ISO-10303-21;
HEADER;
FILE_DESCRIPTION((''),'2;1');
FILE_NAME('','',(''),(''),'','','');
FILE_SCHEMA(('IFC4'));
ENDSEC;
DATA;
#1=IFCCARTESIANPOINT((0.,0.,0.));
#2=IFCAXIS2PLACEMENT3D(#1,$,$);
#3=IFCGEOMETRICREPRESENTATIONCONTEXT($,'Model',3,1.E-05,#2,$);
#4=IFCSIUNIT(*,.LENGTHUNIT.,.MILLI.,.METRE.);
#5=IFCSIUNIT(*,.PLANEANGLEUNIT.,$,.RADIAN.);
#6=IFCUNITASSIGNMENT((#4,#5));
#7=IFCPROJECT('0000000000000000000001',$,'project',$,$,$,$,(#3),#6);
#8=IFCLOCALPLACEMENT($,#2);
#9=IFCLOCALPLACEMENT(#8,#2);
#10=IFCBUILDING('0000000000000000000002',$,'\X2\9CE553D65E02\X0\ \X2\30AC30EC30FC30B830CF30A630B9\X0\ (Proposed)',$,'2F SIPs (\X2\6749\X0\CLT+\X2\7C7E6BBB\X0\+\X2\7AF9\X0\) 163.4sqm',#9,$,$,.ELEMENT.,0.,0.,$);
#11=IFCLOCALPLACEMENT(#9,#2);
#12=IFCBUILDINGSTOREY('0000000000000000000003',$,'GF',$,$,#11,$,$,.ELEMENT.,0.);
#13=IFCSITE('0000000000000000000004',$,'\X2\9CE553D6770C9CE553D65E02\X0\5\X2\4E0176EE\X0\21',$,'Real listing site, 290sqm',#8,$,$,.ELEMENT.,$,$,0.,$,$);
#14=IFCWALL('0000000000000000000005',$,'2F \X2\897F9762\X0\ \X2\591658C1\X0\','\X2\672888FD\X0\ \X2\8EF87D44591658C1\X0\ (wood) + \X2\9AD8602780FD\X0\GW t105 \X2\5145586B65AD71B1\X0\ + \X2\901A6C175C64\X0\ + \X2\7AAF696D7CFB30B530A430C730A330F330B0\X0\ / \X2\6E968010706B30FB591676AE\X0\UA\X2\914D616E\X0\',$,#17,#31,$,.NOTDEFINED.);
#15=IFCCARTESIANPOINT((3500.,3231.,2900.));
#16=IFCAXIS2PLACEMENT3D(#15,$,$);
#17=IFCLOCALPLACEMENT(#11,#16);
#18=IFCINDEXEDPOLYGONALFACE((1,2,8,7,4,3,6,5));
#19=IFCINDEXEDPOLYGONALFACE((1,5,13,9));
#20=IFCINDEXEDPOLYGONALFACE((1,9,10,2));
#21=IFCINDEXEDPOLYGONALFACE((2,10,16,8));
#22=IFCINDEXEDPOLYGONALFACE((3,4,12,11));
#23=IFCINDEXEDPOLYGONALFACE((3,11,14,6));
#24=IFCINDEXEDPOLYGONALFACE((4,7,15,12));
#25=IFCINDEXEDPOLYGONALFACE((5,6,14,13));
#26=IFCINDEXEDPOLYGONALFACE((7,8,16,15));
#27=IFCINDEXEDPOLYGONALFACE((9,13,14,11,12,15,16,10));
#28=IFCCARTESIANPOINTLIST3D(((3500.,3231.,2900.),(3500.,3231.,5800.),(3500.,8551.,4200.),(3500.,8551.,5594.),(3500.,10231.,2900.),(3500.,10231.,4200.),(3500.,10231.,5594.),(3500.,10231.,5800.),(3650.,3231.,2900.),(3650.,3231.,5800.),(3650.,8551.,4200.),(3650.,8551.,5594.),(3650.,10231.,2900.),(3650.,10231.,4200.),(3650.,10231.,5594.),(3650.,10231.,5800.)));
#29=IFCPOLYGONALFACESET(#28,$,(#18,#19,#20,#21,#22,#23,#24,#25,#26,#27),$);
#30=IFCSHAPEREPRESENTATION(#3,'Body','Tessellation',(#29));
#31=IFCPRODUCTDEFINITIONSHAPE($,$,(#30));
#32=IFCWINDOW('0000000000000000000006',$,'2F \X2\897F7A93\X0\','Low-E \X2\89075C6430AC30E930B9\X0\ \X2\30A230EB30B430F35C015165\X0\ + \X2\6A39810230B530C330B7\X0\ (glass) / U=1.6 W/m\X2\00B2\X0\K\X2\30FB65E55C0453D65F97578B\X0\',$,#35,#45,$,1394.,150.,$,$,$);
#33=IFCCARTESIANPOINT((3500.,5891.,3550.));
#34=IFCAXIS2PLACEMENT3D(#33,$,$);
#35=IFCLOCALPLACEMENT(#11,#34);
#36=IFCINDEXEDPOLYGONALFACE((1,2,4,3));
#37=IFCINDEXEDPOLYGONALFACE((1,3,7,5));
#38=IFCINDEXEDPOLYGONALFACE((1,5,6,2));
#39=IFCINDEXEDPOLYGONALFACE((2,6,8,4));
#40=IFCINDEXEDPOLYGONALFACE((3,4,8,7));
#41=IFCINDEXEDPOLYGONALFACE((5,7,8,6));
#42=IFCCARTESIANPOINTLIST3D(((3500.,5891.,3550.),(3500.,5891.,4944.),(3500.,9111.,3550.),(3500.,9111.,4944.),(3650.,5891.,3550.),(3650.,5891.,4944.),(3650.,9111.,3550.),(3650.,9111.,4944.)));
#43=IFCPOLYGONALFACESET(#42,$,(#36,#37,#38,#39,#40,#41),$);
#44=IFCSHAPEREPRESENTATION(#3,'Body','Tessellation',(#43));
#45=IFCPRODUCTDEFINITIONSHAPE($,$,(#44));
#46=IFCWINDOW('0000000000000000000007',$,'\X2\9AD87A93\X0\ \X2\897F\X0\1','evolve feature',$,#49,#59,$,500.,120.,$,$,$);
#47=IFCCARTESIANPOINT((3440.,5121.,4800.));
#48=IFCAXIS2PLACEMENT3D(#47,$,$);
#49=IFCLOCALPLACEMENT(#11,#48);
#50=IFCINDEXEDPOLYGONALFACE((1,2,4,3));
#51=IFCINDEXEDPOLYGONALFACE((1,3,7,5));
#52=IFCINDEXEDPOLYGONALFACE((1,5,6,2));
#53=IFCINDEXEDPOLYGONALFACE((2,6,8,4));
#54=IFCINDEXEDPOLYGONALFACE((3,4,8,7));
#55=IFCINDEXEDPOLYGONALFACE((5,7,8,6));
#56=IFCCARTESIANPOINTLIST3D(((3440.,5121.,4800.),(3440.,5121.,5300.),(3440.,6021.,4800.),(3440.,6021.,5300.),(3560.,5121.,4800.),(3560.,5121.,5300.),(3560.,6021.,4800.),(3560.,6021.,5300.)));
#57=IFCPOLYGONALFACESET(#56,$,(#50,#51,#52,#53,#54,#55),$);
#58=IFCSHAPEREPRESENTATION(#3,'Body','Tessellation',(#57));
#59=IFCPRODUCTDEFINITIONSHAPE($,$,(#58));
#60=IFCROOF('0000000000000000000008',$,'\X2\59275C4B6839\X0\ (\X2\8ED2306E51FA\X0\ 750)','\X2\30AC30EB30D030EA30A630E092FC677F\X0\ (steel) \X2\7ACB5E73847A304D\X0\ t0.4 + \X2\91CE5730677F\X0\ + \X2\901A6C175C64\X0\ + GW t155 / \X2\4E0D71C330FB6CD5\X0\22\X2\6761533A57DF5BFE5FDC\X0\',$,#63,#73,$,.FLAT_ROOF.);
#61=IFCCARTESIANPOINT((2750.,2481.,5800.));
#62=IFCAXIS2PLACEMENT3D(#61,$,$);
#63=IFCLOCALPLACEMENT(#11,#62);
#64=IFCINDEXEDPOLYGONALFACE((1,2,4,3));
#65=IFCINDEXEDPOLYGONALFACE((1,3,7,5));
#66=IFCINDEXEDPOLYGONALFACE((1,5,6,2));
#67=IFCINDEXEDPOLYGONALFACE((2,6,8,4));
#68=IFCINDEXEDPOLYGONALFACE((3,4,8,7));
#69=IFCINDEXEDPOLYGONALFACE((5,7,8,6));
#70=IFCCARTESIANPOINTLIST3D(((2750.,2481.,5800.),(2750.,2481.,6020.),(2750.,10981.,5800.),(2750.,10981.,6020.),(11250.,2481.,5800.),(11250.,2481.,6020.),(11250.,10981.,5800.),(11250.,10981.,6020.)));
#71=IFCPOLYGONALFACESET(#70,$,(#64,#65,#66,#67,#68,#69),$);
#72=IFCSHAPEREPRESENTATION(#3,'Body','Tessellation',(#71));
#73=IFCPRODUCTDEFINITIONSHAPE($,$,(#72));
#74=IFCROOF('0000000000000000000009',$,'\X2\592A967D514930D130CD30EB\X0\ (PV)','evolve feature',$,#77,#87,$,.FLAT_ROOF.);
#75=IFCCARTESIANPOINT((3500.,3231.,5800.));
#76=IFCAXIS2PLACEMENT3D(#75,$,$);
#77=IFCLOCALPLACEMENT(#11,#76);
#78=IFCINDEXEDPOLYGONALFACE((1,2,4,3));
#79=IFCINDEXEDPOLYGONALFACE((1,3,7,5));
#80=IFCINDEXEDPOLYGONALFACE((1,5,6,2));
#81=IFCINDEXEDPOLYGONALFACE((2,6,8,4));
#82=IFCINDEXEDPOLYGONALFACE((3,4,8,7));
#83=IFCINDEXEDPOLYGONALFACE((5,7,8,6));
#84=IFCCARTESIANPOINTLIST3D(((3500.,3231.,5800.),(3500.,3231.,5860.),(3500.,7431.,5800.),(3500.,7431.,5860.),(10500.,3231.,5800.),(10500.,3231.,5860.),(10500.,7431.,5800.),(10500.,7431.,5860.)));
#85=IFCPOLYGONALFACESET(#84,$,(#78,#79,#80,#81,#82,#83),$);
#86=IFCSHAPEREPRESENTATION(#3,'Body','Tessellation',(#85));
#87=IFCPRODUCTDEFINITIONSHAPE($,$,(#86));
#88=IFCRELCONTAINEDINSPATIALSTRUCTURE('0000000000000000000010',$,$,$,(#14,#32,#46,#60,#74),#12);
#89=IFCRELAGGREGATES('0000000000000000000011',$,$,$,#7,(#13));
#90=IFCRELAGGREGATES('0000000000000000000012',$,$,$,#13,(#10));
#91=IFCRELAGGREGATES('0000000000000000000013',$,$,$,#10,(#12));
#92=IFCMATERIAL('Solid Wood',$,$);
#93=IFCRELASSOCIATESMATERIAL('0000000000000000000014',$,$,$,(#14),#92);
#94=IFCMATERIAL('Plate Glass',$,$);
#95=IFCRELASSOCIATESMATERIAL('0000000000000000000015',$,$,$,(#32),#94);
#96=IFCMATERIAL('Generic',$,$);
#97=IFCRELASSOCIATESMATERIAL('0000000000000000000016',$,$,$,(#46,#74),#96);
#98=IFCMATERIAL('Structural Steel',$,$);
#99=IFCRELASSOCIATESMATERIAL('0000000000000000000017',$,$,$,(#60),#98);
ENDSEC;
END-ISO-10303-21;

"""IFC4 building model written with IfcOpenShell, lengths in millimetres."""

from ifc_helpers import new_model, si_unit, frame, frame_2d, origin, place, context, project, spatial, rectangle, extrude, material, element, fill, save


model = new_model("IFC4")

# Units and contexts
model_context = context("Model", 3, precision=1e-05, world=origin())
ifc_project = project(units=[si_unit("LENGTHUNIT", "METRE", prefix="MILLI"), si_unit("PLANEANGLEUNIT", "RADIAN")], contexts=[model_context])

# Site, building, storey
site_placement = place(None, origin())
site = spatial("IfcSite", under=ifc_project, at=site_placement, Name="鳥取県鳥取市5丁目21", ObjectType="Real listing site, 290sqm", CompositionType="ELEMENT", RefElevation=0.0)
building_placement = place(site_placement, origin())
building = spatial("IfcBuilding", under=site, at=building_placement, Name="鳥取市 ガレージハウス (Proposed)", ObjectType="2F SIPs (杉CLT+籾殻+竹) 163.4sqm", CompositionType="ELEMENT", ElevationOfRefHeight=0.0, ElevationOfTerrain=0.0)
storey_placement = place(building_placement, origin())
storey = spatial("IfcBuildingStorey", under=building, at=storey_placement, Name="GF", CompositionType="ELEMENT", Elevation=0.0)

# Shared definitions
ifc_material_1 = material(Name="Solid Wood")
ifc_material_2 = material(Name="Generic")

# Shared definitions
ifc_material_3 = material(Name="Plate Glass")

# Wall, openings, windows
wall_1_placement = place(storey_placement, frame((3500.0, 3231.0, 2900.0)))
wall_1 = element("IfcWall", 1, at=wall_1_placement, inside=storey, material=ifc_material_1, Name="2F 西面 外壁", Description="木製 軸組外壁 (wood) + 高性能GW t105 充填断熱 + 通気層 + 窯業系サイディング / 準耐火・外皮UA配慮", PredefinedType="NOTDEFINED", context=model_context, shape_type="SweptSolid", body=[
    extrude(rectangle(XDim=150.0, YDim=7000.0, at=frame_2d((75.0, 3500.0))), frame((3500.0, 3231.0, 2900.0)), (0.0, 0.0, 1.0), 2900.0),
])
opening_1_placement = place(storey_placement, frame((3500.0, 5891.0, 3550.0)))
opening_1 = element("IfcOpeningElement", 2, at=opening_1_placement, cuts=wall_1, PredefinedType="NOTDEFINED", context=model_context, shape_type="SweptSolid", body=[
    extrude(rectangle(XDim=150.0, YDim=3220.0, at=frame_2d((75.0, 1610.0))), frame((3500.0, 5891.0, 3550.0)), (0.0, 0.0, 1.0), 1394.0),
])
opening_2_placement = place(storey_placement, frame((3440.0, 5121.0, 4800.0)))
opening_2 = element("IfcOpeningElement", 3, at=opening_2_placement, cuts=wall_1, PredefinedType="NOTDEFINED", context=model_context, shape_type="SweptSolid", body=[
    extrude(rectangle(XDim=120.0, YDim=900.0, at=frame_2d((60.0, 450.0))), frame((3440.0, 5121.0, 4800.0)), (0.0, 0.0, 1.0), 500.0),
])
window_1_placement = place(storey_placement, frame((3500.0, 5891.0, 3550.0)))
window_1 = element("IfcWindow", 4, at=window_1_placement, inside=storey, material=ifc_material_3, Name="2F 西窓", Description="Low-E 複層ガラス アルゴン封入 + 樹脂サッシ (glass) / U=1.6 W/m²K・日射取得型", OverallHeight=1394.0, OverallWidth=150.0, context=model_context, shape_type="SweptSolid", body=[
    extrude(rectangle(XDim=150.0, YDim=3220.0, at=frame_2d((75.0, 1610.0))), frame((3500.0, 5891.0, 3550.0)), (0.0, 0.0, 1.0), 1394.0),
])
fill(opening_1, window_1)
window_2_placement = place(storey_placement, frame((3440.0, 5121.0, 4800.0)))
window_2 = element("IfcWindow", 5, at=window_2_placement, inside=storey, material=ifc_material_2, Name="高窓 西1", Description="evolve feature", OverallHeight=500.0, OverallWidth=120.0, context=model_context, shape_type="SweptSolid", body=[
    extrude(rectangle(XDim=120.0, YDim=900.0, at=frame_2d((60.0, 450.0))), frame((3440.0, 5121.0, 4800.0)), (0.0, 0.0, 1.0), 500.0),
])
fill(opening_2, window_2)

# Roofs
ifc_material_4 = material(Name="Structural Steel")
roof_1_placement = place(storey_placement, frame((2750.0, 2481.0, 5800.0)))
element("IfcRoof", 6, at=roof_1_placement, inside=storey, material=ifc_material_4, Name="大屋根 (軒の出 750)", Description="ガルバリウム鋼板 (steel) 立平葺き t0.4 + 野地板 + 通気層 + GW t155 / 不燃・法22条区域対応", PredefinedType="FLAT_ROOF", context=model_context, shape_type="SweptSolid", body=[
    extrude(rectangle(XDim=8500.0, YDim=8500.0, at=frame_2d((4250.0, 4250.0))), frame((2750.0, 2481.0, 5800.0)), (0.0, 0.0, 1.0), 220.0),
])
roof_2_placement = place(storey_placement, frame((3500.0, 3231.0, 5800.0)))
element("IfcRoof", 7, at=roof_2_placement, inside=storey, material=ifc_material_2, Name="太陽光パネル (PV)", Description="evolve feature", PredefinedType="FLAT_ROOF", context=model_context, shape_type="SweptSolid", body=[
    extrude(rectangle(XDim=7000.0, YDim=4200.0, at=frame_2d((3500.0, 2100.0))), frame((3500.0, 3231.0, 5800.0)), (0.0, 0.0, 1.0), 60.0),
])

save(model, "model.ifc")
